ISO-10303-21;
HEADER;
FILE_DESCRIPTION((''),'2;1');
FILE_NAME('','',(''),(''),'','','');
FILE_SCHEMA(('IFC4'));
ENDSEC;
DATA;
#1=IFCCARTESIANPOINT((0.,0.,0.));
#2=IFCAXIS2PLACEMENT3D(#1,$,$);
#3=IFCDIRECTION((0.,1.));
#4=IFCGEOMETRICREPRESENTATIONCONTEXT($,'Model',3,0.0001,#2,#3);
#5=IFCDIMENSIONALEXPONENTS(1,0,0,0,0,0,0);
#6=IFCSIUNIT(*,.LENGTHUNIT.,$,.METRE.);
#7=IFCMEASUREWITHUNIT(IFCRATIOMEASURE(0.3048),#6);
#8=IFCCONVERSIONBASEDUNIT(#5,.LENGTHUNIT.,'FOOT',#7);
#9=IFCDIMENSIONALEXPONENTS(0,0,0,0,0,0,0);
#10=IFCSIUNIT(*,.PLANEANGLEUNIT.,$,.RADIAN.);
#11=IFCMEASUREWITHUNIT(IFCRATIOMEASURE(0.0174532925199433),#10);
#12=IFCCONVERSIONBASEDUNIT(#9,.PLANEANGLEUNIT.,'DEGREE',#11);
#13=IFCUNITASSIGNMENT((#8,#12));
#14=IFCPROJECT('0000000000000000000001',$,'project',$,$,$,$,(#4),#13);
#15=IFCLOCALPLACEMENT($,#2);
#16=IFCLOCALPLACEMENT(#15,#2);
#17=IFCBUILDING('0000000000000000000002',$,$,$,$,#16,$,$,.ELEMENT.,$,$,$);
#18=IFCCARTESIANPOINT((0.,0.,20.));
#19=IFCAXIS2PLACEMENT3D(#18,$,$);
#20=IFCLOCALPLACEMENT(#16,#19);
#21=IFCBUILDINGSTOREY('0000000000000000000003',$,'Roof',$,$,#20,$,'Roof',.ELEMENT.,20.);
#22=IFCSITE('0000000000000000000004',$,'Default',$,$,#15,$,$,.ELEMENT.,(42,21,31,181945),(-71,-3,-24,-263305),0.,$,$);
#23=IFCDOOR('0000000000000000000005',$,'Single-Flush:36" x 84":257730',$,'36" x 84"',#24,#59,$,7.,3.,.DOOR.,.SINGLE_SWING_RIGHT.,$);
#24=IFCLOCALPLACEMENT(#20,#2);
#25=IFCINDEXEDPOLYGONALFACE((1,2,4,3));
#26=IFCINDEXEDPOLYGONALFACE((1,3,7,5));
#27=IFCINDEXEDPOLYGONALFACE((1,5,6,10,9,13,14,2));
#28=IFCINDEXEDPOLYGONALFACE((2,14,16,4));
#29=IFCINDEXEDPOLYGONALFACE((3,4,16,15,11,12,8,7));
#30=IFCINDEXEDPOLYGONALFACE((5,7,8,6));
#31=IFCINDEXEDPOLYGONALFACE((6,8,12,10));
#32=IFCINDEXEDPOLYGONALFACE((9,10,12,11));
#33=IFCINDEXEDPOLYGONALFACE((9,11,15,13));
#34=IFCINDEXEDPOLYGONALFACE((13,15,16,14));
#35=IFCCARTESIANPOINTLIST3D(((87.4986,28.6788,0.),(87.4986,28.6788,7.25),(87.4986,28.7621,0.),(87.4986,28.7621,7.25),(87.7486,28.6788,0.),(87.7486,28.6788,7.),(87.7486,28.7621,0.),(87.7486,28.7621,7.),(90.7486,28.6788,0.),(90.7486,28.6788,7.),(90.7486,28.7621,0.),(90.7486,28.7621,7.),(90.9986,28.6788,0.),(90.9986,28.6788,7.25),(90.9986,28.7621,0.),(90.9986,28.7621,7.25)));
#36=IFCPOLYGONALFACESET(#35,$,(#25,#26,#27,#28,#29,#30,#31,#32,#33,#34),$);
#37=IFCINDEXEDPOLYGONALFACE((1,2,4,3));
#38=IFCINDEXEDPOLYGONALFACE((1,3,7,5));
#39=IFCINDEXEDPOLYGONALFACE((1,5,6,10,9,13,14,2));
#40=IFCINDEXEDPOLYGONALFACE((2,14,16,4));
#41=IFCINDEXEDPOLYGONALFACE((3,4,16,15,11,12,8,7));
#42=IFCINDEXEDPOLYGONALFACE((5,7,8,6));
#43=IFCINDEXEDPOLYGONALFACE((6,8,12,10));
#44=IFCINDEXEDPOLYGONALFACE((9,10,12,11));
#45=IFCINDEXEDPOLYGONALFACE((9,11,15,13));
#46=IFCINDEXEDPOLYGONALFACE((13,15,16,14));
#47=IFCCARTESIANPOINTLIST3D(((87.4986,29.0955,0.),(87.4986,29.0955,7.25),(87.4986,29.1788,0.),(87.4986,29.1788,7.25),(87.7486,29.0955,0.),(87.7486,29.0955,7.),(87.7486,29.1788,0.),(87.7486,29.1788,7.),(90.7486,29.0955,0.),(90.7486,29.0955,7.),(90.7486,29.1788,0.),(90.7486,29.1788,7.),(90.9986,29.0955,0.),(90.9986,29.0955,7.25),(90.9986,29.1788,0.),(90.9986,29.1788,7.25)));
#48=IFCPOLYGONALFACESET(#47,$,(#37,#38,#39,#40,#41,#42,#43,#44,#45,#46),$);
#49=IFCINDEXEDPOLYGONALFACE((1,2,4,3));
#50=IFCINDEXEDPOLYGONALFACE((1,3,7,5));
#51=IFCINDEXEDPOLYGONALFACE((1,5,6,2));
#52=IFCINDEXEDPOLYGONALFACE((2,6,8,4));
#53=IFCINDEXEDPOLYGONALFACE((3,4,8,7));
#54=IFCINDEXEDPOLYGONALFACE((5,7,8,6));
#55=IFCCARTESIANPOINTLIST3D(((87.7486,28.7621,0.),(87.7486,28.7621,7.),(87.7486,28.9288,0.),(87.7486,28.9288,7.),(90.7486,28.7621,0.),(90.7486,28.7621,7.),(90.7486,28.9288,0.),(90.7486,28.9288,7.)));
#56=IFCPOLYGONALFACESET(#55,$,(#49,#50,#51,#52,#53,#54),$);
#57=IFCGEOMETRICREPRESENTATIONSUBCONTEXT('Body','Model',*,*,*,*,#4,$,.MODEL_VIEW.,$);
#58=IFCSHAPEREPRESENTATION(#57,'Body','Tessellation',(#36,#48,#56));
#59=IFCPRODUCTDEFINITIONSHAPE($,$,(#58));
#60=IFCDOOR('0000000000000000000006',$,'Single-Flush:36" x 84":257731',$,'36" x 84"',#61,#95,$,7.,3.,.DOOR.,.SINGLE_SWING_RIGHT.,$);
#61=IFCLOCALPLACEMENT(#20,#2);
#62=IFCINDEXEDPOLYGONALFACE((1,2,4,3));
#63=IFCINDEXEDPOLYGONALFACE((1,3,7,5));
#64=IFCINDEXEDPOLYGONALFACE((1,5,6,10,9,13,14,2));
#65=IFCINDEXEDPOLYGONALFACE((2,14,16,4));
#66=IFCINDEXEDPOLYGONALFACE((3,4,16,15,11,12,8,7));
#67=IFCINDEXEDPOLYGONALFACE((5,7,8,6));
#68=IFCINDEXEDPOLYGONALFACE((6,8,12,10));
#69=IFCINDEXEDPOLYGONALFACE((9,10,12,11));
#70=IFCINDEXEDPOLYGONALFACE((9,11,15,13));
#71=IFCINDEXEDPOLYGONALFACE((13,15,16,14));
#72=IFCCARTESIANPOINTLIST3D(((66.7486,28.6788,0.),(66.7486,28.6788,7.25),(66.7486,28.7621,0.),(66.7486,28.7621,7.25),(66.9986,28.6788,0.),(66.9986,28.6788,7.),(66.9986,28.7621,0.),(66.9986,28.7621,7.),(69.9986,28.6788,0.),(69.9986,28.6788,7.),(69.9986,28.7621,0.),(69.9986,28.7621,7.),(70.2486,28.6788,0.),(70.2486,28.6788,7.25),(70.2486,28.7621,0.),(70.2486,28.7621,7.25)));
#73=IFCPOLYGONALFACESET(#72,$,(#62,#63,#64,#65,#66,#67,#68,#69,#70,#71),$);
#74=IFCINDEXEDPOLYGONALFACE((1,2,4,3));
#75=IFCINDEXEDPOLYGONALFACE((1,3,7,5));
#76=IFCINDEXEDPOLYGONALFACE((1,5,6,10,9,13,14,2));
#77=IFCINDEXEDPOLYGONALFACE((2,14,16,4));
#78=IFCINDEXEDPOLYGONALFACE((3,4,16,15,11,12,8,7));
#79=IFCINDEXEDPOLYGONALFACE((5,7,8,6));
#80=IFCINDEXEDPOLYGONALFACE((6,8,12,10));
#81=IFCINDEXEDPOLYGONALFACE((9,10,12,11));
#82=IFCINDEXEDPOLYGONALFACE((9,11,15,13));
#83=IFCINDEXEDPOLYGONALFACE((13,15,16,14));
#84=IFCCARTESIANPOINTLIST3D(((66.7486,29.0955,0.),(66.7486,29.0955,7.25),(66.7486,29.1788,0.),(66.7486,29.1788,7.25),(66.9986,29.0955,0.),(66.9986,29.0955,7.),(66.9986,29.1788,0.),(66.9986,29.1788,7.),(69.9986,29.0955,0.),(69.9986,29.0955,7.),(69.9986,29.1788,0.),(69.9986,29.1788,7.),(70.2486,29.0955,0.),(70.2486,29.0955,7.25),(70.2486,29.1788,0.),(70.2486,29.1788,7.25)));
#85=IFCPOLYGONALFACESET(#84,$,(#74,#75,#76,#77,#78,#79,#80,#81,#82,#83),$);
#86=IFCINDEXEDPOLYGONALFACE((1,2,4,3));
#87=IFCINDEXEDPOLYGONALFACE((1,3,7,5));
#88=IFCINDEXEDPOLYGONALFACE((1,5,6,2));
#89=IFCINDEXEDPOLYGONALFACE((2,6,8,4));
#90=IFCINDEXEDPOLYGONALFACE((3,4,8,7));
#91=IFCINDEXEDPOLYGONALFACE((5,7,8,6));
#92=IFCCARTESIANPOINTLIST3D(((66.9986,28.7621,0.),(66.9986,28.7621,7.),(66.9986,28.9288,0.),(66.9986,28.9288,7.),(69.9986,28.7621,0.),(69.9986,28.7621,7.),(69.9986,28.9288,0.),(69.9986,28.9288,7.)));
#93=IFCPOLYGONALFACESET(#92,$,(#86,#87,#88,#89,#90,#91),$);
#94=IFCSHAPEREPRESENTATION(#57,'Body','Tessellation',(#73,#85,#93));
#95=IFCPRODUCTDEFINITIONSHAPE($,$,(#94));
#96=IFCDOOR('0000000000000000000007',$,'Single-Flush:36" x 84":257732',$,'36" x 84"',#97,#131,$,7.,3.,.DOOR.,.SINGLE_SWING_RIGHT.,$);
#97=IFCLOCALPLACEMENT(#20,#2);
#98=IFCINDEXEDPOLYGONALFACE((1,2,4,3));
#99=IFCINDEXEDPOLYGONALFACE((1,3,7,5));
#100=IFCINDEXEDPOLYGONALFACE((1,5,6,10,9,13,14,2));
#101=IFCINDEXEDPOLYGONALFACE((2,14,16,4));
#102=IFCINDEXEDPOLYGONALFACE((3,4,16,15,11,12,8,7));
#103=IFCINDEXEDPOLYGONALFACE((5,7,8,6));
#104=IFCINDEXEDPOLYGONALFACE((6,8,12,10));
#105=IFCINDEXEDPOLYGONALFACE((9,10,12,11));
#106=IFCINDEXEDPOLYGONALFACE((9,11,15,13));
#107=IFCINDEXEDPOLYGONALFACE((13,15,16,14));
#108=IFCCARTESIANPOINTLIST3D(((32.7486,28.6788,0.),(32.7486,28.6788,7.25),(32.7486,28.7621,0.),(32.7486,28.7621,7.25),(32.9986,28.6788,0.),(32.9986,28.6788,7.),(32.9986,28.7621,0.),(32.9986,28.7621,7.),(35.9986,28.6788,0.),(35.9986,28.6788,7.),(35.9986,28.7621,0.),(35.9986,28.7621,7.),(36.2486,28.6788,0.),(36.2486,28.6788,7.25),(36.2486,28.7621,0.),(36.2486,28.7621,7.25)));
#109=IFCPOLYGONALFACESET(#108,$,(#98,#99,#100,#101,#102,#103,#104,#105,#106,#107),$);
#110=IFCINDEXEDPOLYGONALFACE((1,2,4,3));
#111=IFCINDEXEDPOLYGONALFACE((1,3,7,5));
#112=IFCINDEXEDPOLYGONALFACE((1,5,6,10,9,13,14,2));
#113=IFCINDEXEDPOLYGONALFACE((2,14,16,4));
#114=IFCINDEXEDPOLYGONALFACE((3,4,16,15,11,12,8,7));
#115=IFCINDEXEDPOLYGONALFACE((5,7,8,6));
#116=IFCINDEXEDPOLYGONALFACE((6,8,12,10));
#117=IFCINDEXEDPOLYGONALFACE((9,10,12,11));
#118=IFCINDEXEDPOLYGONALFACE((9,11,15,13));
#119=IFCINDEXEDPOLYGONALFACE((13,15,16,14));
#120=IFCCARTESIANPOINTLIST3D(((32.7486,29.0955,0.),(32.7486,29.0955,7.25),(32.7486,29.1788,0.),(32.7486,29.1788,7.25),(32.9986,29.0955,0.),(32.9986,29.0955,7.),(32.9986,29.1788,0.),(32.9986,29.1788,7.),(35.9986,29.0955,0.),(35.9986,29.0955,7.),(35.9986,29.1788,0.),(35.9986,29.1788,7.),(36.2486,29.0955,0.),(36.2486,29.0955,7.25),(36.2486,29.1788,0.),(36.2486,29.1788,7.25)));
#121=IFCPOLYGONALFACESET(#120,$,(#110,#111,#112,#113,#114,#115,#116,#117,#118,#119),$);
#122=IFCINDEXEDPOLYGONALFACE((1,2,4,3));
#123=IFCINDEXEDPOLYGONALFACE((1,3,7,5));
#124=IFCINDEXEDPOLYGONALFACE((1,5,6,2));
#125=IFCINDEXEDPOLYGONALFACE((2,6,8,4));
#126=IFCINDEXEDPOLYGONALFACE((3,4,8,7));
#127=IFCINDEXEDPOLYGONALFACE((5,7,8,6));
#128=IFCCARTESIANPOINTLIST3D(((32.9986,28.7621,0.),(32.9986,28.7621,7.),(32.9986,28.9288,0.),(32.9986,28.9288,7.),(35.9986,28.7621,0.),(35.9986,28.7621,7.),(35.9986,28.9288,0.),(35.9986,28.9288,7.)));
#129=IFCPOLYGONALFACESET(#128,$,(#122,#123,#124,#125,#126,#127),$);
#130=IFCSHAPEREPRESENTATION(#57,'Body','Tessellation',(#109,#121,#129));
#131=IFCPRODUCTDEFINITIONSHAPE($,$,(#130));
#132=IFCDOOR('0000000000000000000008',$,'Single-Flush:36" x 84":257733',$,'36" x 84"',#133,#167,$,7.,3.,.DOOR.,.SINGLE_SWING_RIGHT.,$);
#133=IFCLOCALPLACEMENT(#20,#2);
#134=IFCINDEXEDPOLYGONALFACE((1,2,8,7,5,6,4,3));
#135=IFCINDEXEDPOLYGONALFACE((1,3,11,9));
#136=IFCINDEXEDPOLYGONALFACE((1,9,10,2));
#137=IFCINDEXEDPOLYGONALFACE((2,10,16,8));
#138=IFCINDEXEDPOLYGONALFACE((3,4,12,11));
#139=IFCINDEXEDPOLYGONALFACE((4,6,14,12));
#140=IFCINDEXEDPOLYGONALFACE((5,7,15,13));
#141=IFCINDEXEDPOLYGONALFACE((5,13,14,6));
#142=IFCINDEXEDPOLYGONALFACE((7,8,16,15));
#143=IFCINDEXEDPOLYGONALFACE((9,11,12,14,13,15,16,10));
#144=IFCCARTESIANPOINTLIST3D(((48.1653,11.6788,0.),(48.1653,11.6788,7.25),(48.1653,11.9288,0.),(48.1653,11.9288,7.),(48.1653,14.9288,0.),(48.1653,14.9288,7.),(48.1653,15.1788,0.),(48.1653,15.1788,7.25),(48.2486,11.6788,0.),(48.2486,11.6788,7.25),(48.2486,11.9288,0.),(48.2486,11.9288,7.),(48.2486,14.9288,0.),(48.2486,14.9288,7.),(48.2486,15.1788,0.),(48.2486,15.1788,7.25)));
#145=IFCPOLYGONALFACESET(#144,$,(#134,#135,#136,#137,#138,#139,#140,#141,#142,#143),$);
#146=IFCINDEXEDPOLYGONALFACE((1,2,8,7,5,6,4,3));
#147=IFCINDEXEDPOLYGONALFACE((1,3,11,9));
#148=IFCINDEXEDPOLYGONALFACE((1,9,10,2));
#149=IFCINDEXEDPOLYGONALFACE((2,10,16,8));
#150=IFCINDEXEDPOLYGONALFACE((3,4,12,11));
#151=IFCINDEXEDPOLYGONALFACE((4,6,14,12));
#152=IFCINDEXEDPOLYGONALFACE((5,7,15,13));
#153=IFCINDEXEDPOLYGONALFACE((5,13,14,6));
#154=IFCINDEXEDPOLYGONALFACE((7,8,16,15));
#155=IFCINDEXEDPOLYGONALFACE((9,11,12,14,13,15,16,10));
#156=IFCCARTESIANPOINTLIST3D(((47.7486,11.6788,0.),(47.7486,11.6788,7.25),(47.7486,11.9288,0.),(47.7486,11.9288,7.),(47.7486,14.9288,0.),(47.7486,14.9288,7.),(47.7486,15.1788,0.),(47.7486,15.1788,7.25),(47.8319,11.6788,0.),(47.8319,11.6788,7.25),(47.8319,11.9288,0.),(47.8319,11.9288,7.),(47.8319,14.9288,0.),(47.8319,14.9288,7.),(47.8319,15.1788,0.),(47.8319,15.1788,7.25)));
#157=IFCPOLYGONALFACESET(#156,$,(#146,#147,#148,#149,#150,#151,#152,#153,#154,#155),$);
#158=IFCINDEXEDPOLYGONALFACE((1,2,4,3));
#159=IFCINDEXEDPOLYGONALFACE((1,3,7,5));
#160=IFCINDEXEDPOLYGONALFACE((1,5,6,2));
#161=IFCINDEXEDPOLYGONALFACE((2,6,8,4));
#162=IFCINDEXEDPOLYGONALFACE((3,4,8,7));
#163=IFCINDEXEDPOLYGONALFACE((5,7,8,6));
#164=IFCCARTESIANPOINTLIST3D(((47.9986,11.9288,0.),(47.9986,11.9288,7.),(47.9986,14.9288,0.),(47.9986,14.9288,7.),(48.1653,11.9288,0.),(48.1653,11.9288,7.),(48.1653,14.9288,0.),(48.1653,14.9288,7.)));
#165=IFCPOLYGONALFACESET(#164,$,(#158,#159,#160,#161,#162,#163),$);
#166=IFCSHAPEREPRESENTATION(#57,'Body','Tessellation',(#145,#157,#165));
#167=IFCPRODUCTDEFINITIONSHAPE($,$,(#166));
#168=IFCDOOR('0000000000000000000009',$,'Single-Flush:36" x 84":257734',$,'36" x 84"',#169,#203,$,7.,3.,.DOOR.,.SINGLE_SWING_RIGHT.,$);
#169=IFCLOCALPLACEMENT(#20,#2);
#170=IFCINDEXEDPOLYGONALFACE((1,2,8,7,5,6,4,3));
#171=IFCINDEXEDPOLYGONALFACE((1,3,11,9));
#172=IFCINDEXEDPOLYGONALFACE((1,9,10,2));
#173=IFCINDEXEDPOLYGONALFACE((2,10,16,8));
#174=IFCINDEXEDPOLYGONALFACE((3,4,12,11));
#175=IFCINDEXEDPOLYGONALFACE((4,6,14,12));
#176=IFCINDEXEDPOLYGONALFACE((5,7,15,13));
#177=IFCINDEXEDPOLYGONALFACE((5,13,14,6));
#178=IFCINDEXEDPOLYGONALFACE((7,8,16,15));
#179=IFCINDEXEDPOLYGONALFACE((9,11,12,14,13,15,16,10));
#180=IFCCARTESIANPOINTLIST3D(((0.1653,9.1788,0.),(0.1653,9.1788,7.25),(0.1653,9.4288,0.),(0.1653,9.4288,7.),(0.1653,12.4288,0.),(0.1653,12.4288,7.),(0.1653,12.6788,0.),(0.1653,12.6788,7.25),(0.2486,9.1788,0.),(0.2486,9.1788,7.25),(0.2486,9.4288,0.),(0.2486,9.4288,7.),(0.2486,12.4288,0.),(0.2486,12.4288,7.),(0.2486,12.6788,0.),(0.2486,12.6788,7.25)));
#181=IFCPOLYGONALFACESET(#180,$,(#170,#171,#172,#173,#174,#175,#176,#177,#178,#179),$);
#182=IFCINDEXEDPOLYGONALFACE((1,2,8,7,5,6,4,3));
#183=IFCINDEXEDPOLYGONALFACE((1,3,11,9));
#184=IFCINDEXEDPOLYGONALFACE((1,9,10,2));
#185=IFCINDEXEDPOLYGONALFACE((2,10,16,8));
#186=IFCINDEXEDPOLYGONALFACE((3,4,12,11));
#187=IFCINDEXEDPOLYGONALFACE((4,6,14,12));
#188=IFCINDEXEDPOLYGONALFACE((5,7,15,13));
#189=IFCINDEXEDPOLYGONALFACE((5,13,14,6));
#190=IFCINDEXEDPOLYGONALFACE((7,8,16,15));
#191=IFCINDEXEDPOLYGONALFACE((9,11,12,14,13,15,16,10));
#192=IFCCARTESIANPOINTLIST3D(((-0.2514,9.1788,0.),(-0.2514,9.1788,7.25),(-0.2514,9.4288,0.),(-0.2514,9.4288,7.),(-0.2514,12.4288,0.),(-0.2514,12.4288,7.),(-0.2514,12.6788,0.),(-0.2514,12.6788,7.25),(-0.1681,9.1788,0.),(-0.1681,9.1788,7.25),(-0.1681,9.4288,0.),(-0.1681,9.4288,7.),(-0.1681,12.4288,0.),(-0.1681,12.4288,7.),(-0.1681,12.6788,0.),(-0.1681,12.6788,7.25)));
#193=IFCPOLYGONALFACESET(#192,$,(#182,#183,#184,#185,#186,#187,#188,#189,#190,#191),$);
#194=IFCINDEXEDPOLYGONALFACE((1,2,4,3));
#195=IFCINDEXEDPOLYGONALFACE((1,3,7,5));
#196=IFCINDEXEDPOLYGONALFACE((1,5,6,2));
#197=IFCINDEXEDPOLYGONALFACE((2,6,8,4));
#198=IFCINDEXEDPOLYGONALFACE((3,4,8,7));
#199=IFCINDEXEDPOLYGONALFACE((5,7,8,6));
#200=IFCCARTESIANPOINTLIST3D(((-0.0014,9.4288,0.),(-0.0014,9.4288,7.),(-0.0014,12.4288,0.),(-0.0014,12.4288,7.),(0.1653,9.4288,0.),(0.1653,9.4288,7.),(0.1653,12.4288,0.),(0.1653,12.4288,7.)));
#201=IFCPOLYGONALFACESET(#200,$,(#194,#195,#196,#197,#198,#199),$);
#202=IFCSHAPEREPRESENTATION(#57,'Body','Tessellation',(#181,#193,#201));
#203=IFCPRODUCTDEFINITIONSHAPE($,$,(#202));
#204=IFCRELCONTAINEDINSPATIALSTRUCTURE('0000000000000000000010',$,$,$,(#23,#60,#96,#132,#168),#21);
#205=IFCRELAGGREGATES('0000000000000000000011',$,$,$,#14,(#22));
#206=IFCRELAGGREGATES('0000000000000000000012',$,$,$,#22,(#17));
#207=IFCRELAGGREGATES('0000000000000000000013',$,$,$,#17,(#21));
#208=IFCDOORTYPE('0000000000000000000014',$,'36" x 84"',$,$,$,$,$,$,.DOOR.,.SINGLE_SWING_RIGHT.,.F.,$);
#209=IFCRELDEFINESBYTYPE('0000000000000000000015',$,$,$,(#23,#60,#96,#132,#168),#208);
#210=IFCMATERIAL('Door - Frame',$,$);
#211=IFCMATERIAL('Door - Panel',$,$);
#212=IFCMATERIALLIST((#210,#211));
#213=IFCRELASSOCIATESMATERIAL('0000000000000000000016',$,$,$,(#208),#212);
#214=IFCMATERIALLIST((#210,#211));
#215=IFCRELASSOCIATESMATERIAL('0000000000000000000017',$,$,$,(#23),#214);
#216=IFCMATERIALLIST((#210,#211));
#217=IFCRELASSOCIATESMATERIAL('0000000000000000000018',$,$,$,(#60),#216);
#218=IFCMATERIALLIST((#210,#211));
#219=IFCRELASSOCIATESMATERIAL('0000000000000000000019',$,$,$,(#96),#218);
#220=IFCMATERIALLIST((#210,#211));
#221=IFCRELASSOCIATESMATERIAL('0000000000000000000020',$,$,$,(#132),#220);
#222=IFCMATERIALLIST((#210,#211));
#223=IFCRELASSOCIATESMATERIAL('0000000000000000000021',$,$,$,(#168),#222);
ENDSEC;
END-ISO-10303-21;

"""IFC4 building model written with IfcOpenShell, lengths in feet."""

from ifc_helpers import new_model, entity, si_unit, converted_unit, direction, frame, frame_2d, origin, place, context, subcontext, project, spatial, polyline, rectangle, outline, extrude, source, transform, mapped, material, material_list, type_object, type_shapes, element, save


model = new_model("IFC4")

# Units and contexts
model_context = context("Model", 3, precision=0.0001, world=origin(), true_north=direction((0.0, 1.0)))
body_context = subcontext(model_context, "Body", "Model", "MODEL_VIEW")
ifc_project = project(units=[converted_unit("LENGTHUNIT", "FOOT", entity("IfcRatioMeasure", 0.3048), si_unit("LENGTHUNIT", "METRE"), dimensions=[1, 0, 0, 0, 0, 0, 0]), converted_unit("PLANEANGLEUNIT", "DEGREE", entity("IfcRatioMeasure", 0.0174532925199433), si_unit("PLANEANGLEUNIT", "RADIAN"), dimensions=[0, 0, 0, 0, 0, 0, 0])], contexts=[model_context])

# Site, building, storey
site_placement = place(None, origin())
site = spatial("IfcSite", under=ifc_project, at=site_placement, Name="Default", CompositionType="ELEMENT", RefLatitude=(42, 21, 31, 181945), RefLongitude=(-71, -3, -24, -263305), RefElevation=0.0)
building_placement = place(site_placement, origin())
building = spatial("IfcBuilding", under=site, at=building_placement, CompositionType="ELEMENT")
storey_placement = place(building_placement, frame((0.0, 0.0, 20.0)))
storey = spatial("IfcBuildingStorey", under=building, at=storey_placement, Name="Roof", LongName="Roof", CompositionType="ELEMENT", Elevation=20.0)

# Shared definitions
placement_1 = place(building_placement, frame((0.0, 0.0, 10.0)))
placement_2 = place(placement_1, frame((-0.1681, 28.9288, 0.0)))
placement_3 = place(placement_1, frame((-0.0014, -6.9045, 0.0), z_axis=(0.0, 0.0, 1.0), x_axis=(0.0, 1.0, 0.0)))

# Doors
ifc_material_1 = material(Name="Door - Frame")
ifc_material_2 = material(Name="Door - Panel")
ifc_material_list_1 = material_list([ifc_material_1, ifc_material_2])
door_type = type_object("IfcDoorType", Name="36\" x 84\"", OperationType="SINGLE_SWING_RIGHT", ParameterTakesPrecedence=False, PredefinedType="DOOR", material=ifc_material_list_1)
shared_shape_1 = source(origin(), body_context, "Body", "SweptSolid", [
    extrude(outline(polyline([(-1.75, -3.6875), (1.75, -3.6875), (1.75, 3.5625), (1.5, 3.5625), (1.5, -3.4375), (-1.5, -3.4375), (-1.5, 3.5625), (-1.75, 3.5625), (-1.75, -3.6875)])), frame((1.5, 0.3333, 3.5625), z_axis=(0.0, 1.0, 0.0), x_axis=(1.0, 0.0, 0.0)), (0.0, 0.0, 1.0), 0.0833),
    extrude(outline(polyline([(-3.6875, -1.75), (3.5625, -1.75), (3.5625, -1.5), (-3.4375, -1.5), (-3.4375, 1.5), (3.5625, 1.5), (3.5625, 1.75), (-3.6875, 1.75), (-3.6875, -1.75)])), frame((1.5, -0.0833, 3.5625), z_axis=(0.0, 1.0, 0.0), x_axis=(0.0, 0.0, -1.0)), (0.0, 0.0, 1.0), 0.0833),
    extrude(rectangle(XDim=0.1667, YDim=3.0, at=frame_2d((0.0, 0.0), x_axis=(1.0, 0.0))), frame((1.5, 0.25, 0.0), z_axis=(0.0, 0.0, 1.0), x_axis=(0.0, 1.0, 0.0)), (0.0, 0.0, 1.0), 7.0),
])
type_shapes(door_type, [shared_shape_1])
ifc_material_list_2 = material_list([ifc_material_1, ifc_material_2])
placement_4 = place(placement_2, frame((90.9167, 0.1667, 10.0)))
door_1_placement = place(placement_4, frame((0.0, 0.0, 0.0), z_axis=(0.0, 0.0, 1.0), x_axis=(-1.0, 0.0, 0.0)))
element("IfcDoor", 1, at=door_1_placement, inside=storey, type_object=door_type, material=ifc_material_list_2, Name="Single-Flush:36\" x 84\":257730", ObjectType="36\" x 84\"", OperationType="SINGLE_SWING_RIGHT", OverallHeight=7.0, OverallWidth=3.0, PredefinedType="DOOR", context=body_context, shape_type="MappedRepresentation", body=[
    mapped(shared_shape_1, transform((0.0, 0.0, 0.0), scale=1.0)),
])
ifc_material_list_3 = material_list([ifc_material_1, ifc_material_2])
placement_5 = place(placement_2, frame((70.1667, 0.1667, 10.0)))
door_2_placement = place(placement_5, frame((0.0, 0.0, 0.0), z_axis=(0.0, 0.0, 1.0), x_axis=(-1.0, 0.0, 0.0)))
element("IfcDoor", 2, at=door_2_placement, inside=storey, type_object=door_type, material=ifc_material_list_3, Name="Single-Flush:36\" x 84\":257731", ObjectType="36\" x 84\"", OperationType="SINGLE_SWING_RIGHT", OverallHeight=7.0, OverallWidth=3.0, PredefinedType="DOOR", context=body_context, shape_type="MappedRepresentation", body=[
    mapped(shared_shape_1, transform((0.0, 0.0, 0.0), scale=1.0)),
])
ifc_material_list_4 = material_list([ifc_material_1, ifc_material_2])
placement_6 = place(placement_2, frame((36.1667, 0.1667, 10.0)))
door_3_placement = place(placement_6, frame((0.0, 0.0, 0.0), z_axis=(0.0, 0.0, 1.0), x_axis=(-1.0, 0.0, 0.0)))
element("IfcDoor", 3, at=door_3_placement, inside=storey, type_object=door_type, material=ifc_material_list_4, Name="Single-Flush:36\" x 84\":257732", ObjectType="36\" x 84\"", OperationType="SINGLE_SWING_RIGHT", OverallHeight=7.0, OverallWidth=3.0, PredefinedType="DOOR", context=body_context, shape_type="MappedRepresentation", body=[
    mapped(shared_shape_1, transform((0.0, 0.0, 0.0), scale=1.0)),
])
ifc_material_list_5 = material_list([ifc_material_1, ifc_material_2])
placement_7 = place(placement_1, frame((47.9986, 28.7621, 0.0), z_axis=(0.0, 0.0, 1.0), x_axis=(0.0, -1.0, 0.0)))
placement_8 = place(placement_7, frame((13.8333, -0.1667, 10.0)))
door_4_placement = place(placement_8, origin())
element("IfcDoor", 4, at=door_4_placement, inside=storey, type_object=door_type, material=ifc_material_list_5, Name="Single-Flush:36\" x 84\":257733", ObjectType="36\" x 84\"", OperationType="SINGLE_SWING_RIGHT", OverallHeight=7.0, OverallWidth=3.0, PredefinedType="DOOR", context=body_context, shape_type="MappedRepresentation", body=[
    mapped(shared_shape_1, transform((0.0, 0.0, 0.0), scale=1.0)),
])
ifc_material_list_6 = material_list([ifc_material_1, ifc_material_2])
placement_9 = place(placement_3, frame((19.3333, 0.1667, 10.0)))
door_5_placement = place(placement_9, frame((0.0, 0.0, 0.0), z_axis=(0.0, 0.0, 1.0), x_axis=(-1.0, 0.0, 0.0)))
element("IfcDoor", 5, at=door_5_placement, inside=storey, type_object=door_type, material=ifc_material_list_6, Name="Single-Flush:36\" x 84\":257734", ObjectType="36\" x 84\"", OperationType="SINGLE_SWING_RIGHT", OverallHeight=7.0, OverallWidth=3.0, PredefinedType="DOOR", context=body_context, shape_type="MappedRepresentation", body=[
    mapped(shared_shape_1, transform((0.0, 0.0, 0.0), scale=1.0)),
])

save(model, "model.ifc")
